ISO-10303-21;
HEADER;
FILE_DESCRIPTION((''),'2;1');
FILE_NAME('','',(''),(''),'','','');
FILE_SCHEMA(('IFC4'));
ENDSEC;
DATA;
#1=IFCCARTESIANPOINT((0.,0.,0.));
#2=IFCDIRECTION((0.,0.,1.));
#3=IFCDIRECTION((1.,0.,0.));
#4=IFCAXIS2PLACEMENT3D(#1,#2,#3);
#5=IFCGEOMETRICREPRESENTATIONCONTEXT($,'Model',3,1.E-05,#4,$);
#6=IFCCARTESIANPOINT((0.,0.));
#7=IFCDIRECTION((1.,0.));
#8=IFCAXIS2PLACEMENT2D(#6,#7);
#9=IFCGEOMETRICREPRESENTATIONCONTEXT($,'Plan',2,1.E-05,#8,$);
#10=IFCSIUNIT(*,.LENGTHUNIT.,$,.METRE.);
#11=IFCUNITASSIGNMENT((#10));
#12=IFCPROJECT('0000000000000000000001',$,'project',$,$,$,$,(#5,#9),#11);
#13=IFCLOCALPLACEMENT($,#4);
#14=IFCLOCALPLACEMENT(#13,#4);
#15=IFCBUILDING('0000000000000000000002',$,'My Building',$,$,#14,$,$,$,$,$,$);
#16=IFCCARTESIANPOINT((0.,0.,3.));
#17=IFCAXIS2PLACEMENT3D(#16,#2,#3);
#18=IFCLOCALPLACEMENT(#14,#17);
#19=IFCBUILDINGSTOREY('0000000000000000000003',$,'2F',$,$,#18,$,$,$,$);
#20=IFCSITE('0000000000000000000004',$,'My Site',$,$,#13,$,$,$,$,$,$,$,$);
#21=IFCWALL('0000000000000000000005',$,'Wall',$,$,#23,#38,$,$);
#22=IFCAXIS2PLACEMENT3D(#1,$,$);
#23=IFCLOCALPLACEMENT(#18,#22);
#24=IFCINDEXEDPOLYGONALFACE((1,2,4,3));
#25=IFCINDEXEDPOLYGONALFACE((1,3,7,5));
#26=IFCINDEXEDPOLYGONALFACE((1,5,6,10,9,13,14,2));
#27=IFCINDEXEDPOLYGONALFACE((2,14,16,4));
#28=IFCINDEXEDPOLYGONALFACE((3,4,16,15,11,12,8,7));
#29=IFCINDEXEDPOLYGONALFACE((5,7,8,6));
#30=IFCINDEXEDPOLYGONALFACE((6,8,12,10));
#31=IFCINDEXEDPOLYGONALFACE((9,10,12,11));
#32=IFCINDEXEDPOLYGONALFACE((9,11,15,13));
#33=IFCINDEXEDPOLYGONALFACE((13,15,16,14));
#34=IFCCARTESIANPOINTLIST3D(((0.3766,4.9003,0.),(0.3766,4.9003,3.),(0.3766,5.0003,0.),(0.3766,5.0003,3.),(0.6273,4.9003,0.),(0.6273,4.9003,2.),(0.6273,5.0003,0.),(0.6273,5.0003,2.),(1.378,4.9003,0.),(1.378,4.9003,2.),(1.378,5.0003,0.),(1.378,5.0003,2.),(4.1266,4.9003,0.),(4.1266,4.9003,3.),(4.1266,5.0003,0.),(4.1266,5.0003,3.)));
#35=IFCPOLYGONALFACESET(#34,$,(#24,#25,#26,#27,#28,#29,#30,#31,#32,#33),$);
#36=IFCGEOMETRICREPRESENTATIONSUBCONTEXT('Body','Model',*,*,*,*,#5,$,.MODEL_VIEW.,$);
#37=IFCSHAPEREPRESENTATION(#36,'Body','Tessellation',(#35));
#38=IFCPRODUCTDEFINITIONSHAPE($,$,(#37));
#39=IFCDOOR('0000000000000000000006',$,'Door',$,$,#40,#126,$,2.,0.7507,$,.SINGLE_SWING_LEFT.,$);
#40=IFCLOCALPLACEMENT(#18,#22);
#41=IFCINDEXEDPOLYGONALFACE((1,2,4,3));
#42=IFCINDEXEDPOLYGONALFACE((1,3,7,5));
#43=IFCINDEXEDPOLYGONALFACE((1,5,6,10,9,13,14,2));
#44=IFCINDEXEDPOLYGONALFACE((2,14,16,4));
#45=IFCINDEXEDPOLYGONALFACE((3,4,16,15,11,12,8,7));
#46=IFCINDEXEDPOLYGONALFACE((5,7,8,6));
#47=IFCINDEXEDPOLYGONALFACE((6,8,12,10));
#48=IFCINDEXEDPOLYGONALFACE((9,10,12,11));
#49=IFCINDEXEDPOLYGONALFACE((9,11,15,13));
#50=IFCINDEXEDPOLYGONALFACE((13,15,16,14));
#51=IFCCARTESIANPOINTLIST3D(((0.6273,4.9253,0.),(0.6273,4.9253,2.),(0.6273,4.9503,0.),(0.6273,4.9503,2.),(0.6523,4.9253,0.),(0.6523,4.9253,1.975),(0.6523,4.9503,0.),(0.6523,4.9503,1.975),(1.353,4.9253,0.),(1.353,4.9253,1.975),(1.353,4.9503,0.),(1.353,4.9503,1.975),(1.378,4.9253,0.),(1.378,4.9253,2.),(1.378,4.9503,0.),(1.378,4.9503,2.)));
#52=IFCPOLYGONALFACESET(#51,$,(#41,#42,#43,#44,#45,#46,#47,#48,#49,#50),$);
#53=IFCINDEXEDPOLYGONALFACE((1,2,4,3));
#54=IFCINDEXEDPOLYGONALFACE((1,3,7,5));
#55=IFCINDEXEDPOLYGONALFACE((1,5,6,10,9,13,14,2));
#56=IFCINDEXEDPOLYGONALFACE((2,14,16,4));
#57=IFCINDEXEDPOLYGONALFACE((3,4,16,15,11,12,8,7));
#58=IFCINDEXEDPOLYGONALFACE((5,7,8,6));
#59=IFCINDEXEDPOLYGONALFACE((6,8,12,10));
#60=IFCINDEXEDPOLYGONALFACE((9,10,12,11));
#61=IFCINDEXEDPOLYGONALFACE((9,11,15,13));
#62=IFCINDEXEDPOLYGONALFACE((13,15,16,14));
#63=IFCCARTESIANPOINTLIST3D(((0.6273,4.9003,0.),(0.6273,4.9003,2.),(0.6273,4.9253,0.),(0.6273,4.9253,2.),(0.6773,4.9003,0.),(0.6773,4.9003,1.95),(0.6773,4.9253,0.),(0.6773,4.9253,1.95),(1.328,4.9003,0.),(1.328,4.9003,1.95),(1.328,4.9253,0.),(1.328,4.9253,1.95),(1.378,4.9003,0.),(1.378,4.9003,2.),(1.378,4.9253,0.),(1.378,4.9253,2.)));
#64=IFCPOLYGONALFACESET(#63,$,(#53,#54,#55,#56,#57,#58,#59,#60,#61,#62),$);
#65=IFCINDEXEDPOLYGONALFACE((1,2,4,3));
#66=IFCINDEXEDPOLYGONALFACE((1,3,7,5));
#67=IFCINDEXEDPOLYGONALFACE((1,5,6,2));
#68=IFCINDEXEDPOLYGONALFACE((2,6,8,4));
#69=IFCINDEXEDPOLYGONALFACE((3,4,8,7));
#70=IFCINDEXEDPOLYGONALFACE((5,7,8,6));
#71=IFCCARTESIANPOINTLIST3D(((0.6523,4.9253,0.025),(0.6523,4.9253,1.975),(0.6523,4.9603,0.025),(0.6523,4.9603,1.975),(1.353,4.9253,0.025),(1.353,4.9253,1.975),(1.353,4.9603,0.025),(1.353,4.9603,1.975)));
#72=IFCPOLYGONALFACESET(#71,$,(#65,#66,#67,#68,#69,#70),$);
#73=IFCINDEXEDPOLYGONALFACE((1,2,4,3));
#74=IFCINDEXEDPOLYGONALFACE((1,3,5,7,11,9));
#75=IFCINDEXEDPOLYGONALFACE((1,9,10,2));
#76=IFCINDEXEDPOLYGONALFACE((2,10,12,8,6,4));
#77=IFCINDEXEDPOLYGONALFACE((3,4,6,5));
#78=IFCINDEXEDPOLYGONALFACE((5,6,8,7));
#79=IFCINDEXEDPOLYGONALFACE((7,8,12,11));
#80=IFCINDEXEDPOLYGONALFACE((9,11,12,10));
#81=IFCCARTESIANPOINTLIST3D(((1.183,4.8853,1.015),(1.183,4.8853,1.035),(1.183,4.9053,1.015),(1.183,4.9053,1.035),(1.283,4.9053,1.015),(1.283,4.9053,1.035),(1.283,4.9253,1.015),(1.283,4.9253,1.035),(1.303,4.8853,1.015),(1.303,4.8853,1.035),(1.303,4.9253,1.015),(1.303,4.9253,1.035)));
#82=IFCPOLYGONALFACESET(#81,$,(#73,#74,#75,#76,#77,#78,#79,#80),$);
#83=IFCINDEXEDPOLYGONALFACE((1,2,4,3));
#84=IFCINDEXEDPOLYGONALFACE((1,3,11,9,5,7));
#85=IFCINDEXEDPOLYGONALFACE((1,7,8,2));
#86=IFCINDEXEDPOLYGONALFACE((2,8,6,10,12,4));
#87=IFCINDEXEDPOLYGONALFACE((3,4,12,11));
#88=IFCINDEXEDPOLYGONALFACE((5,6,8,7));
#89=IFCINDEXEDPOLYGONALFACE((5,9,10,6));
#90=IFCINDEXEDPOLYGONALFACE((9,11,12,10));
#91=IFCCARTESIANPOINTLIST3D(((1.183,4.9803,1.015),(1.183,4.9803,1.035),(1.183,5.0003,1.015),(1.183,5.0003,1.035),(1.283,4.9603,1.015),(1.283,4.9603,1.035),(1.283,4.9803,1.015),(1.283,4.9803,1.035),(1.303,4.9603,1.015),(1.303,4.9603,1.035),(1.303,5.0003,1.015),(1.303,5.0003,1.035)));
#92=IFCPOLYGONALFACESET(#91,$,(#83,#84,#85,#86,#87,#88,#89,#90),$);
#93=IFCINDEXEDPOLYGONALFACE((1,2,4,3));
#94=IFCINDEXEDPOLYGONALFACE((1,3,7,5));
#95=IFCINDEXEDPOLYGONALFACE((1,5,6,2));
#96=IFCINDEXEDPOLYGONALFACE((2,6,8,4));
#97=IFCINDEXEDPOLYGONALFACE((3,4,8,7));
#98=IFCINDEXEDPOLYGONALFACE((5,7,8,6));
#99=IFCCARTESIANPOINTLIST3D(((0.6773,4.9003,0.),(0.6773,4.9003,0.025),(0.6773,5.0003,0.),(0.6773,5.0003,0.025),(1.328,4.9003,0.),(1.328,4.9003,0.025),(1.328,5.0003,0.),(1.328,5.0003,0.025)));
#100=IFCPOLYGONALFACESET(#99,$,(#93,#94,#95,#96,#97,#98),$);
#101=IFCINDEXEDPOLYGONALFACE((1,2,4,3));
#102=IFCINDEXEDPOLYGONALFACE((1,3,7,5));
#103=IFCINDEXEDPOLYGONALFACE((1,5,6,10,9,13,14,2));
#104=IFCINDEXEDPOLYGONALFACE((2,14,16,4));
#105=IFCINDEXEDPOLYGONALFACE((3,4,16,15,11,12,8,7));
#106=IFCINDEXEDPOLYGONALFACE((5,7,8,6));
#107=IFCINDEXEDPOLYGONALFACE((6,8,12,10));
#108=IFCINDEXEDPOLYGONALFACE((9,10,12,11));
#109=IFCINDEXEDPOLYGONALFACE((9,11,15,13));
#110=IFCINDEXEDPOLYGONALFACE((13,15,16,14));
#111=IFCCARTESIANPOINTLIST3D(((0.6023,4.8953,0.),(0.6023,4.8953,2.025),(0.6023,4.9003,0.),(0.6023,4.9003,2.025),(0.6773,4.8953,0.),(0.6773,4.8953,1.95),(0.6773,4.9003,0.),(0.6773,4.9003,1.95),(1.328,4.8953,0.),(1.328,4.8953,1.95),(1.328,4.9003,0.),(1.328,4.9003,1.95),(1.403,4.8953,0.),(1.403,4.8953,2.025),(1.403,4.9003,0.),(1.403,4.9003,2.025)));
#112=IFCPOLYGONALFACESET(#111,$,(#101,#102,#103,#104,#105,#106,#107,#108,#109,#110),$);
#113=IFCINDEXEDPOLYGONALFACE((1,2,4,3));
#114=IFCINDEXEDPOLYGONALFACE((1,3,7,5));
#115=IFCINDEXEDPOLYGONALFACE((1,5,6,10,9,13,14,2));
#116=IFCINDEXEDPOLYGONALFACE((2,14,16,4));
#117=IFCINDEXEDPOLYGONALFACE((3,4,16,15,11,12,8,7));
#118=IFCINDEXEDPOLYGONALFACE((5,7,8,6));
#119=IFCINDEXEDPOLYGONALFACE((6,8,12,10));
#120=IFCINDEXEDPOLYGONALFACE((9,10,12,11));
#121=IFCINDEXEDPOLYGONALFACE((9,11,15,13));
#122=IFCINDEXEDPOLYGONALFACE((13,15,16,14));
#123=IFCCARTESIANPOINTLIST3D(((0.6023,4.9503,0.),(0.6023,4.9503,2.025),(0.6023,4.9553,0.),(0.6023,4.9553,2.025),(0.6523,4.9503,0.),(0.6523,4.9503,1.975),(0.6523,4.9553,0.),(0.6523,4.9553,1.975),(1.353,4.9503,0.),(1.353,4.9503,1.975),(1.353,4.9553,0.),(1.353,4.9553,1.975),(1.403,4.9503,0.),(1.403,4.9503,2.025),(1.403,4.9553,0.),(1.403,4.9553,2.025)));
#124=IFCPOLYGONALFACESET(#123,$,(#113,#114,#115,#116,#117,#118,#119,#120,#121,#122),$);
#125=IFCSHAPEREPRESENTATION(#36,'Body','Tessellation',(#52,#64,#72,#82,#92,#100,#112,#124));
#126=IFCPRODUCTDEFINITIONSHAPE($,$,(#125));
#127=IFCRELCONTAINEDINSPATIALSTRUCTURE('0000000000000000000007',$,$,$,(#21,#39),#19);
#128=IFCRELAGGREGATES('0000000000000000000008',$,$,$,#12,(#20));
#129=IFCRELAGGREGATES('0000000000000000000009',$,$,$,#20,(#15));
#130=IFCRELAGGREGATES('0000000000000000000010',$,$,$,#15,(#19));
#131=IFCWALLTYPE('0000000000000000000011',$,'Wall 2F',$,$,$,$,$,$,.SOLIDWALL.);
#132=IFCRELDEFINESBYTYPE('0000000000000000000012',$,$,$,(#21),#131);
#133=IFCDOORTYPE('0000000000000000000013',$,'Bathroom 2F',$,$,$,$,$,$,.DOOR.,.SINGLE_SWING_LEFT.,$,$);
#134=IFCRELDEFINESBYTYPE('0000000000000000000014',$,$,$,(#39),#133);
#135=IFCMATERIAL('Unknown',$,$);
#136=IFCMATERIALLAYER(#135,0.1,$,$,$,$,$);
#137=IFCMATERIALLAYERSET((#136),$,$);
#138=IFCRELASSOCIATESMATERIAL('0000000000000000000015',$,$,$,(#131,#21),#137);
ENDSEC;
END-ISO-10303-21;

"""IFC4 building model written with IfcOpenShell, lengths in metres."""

from ifc_helpers import new_model, entity, si_unit, frame, origin_with_axes, origin_2d_with_axis, place, context, subcontext, project, spatial, line, indexed_curve, outline, extrude, shape, source, transform, mapped, material, layer, layer_set, layer_usage, type_object, type_shapes, element, fill, save


model = new_model("IFC4")

# Units and contexts
model_context = context("Model", 3, precision=1e-05, world=origin_with_axes())
plan_context = context("Plan", 2, precision=1e-05, world=origin_2d_with_axis())
body_context_1 = subcontext(model_context, "Body", "Model", "MODEL_VIEW")
body_context_2 = subcontext(plan_context, "Body", "Plan", "PLAN_VIEW")
ifc_project = project(units=[si_unit("LENGTHUNIT", "METRE")], contexts=[model_context, plan_context])

# Site, building, storey
site_placement = place(None, origin_with_axes())
site = spatial("IfcSite", under=ifc_project, at=site_placement, Name="My Site")
building_placement = place(site_placement, origin_with_axes())
building = spatial("IfcBuilding", under=site, at=building_placement, Name="My Building")
storey_placement = place(building_placement, frame((0.0, 0.0, 3.0), z_axis=(0.0, 0.0, 1.0), x_axis=(1.0, 0.0, 0.0)))
storey = spatial("IfcBuildingStorey", under=building, at=storey_placement, Name="2F")

# Shared definitions
ifc_material = material(Name="Unknown")
ifc_layer_1 = layer(ifc_material, 0.1)
ifc_layer_set_1 = layer_set([ifc_layer_1])
wall_type_1 = type_object("IfcWallType", Name="Wall 2F", PredefinedType="SOLIDWALL", material=ifc_layer_set_1)

# Wall, opening, door
ifc_layer_usage_1 = layer_usage(ifc_layer_set_1, "AXIS2", "POSITIVE", 0.0)
wall_1_placement = place(storey_placement, frame((4.2266, 5.0003, 0.0), z_axis=(0.0, 0.0, 1.0), x_axis=(-1.0, 0.0, 0.0)))
wall_1 = element("IfcWall", 1, at=wall_1_placement, inside=storey, type_object=wall_type_1, material=ifc_layer_usage_1, Name="Wall", context=body_context_1, shape_type="SweptSolid", body=[
    extrude(outline(indexed_curve([(0.1, 0.0), (0.1, 0.1), (3.85, 0.1), (3.85, 0.0)], segments=[line(1, 2, 3, 4, 1)])), origin_with_axes(), (0.0, 0.0, 1.0), 3.0),
])
shared_shape_1 = source(origin_with_axes(), body_context_1, "Body", "SweptSolid", [
    extrude(outline(indexed_curve([(0.0, 0.0), (0.7507, 0.0), (0.7507, 2.0), (0.0, 2.0)], segments=[line(1, 2, 3, 4, 1)])), frame((0.0, -0.6, 0.0), z_axis=(0.0, -1.0, 0.0), x_axis=(1.0, 0.0, 0.0)), (0.0, 0.0, -1.0), 1.2),
])
opening_1_placement = place(wall_1_placement, frame((3.5993, 0.1, 0.0), z_axis=(0.0, 0.0, 1.0), x_axis=(-1.0, 0.000001, 0.0)))
opening_1 = element("IfcOpeningElement", 2, at=opening_1_placement, cuts=wall_1, PredefinedType="OPENING", context=body_context_1, shape_type="MappedRepresentation", body=[
    mapped(shared_shape_1, transform((0.0, 0.0, 0.0), x_axis=(1.0, 0.0, 0.0), y_axis=(0.0, 1.0, 0.0), z_axis=(0.0, 0.0, 1.0), scale=1.0)),
])
door_type_1 = type_object("IfcDoorType", Name="Bathroom 2F", OperationType="SINGLE_SWING_LEFT", PredefinedType="DOOR")
shared_shape_2 = source(origin_with_axes(), body_context_1, "Body", "SweptSolid", [
    extrude(outline(indexed_curve([(0.0, 0.0), (0.0, 2.0), (0.7507, 2.0), (0.7507, 0.0), (0.7257, 0.0), (0.7257, 1.975), (0.025, 1.975), (0.025, 0.0)], segments=[line(1, 2, 3, 4, 5, 6, 7, 8, 1)])), frame((0.0, 0.025, 0.0), z_axis=(0.0, -1.0, 0.0), x_axis=(1.0, 0.0, 0.0)), (0.0, 0.0, -1.0), 0.025),
    extrude(outline(indexed_curve([(0.0, 0.0), (0.0, 2.0), (0.7507, 2.0), (0.7507, 0.0), (0.7007, 0.0), (0.7007, 1.95), (0.05, 1.95), (0.05, 0.0)], segments=[line(1, 2, 3, 4, 5, 6, 7, 8, 1)])), frame((0.0, 0.0, 0.0), z_axis=(0.0, -1.0, 0.0), x_axis=(1.0, 0.0, 0.0)), (0.0, 0.0, -1.0), 0.025),
    extrude(outline(indexed_curve([(0.0, 0.0), (0.7007, 0.0), (0.7007, 0.035), (0.0, 0.035)], segments=[line(1, 2, 3, 4, 1)])), frame((0.025, 0.025, 0.025), z_axis=(0.0, 0.0, 1.0), x_axis=(1.0, 0.0, 0.0)), (0.0, 0.0, 1.0), 1.95),
    extrude(outline(indexed_curve([(0.0, 0.0), (0.0, -0.04), (-0.12, -0.04), (-0.12, -0.02), (-0.02, -0.02), (-0.02, 0.0)], segments=[line(1, 2, 3, 4, 5, 6, 1)])), frame((0.6757, 0.025, 1.015), z_axis=(0.0, 0.0, 1.0), x_axis=(1.0, 0.0, 0.0)), (0.0, 0.0, 1.0), 0.02),
    extrude(outline(indexed_curve([(0.0, 0.0), (0.0, 0.04), (-0.12, 0.04), (-0.12, 0.02), (-0.02, 0.02), (-0.02, 0.0)], segments=[line(1, 2, 3, 4, 5, 6, 1)])), frame((0.6757, 0.06, 1.015), z_axis=(0.0, 0.0, 1.0), x_axis=(1.0, 0.0, 0.0)), (0.0, 0.0, 1.0), 0.02),
    extrude(outline(indexed_curve([(0.0, 0.0), (0.6507, 0.0), (0.6507, 0.1), (0.0, 0.1)], segments=[line(1, 2, 3, 4, 1)])), frame((0.05, 0.0, 0.0), z_axis=(0.0, 0.0, 1.0), x_axis=(1.0, 0.0, 0.0)), (0.0, 0.0, 1.0), 0.025),
    extrude(outline(indexed_curve([(0.0, 0.0), (0.0, 2.025), (0.8007, 2.025), (0.8007, 0.0), (0.7257, 0.0), (0.7257, 1.95), (0.075, 1.95), (0.075, 0.0)], segments=[line(1, 2, 3, 4, 5, 6, 7, 8, 1)])), frame((-0.025, -0.005, 0.0), z_axis=(0.0, -1.0, 0.0), x_axis=(1.0, 0.0, 0.0)), (0.0, 0.0, -1.0), 0.005),
    extrude(outline(indexed_curve([(0.0, 0.0), (0.0, 2.025), (0.8007, 2.025), (0.8007, 0.0), (0.7507, 0.0), (0.7507, 1.975), (0.05, 1.975), (0.05, 0.0)], segments=[line(1, 2, 3, 4, 5, 6, 7, 8, 1)])), frame((-0.025, 0.05, 0.0), z_axis=(0.0, -1.0, 0.0), x_axis=(1.0, 0.0, 0.0)), (0.0, 0.0, -1.0), 0.005),
])
shared_shape_3 = source(origin_with_axes(), body_context_2, "Body", "Curve2D", [
    entity("IfcIndexedPolyCurve", entity("IfcCartesianPointList2D", [[0.0, 0.0], [0.0, 0.05], [0.025, 0.05], [0.025, 0.025], [0.05, 0.025], [0.05, 0.0]]), [entity("IfcLineIndex", [1, 2, 3, 4, 5, 6, 1])]),
    entity("IfcIndexedPolyCurve", entity("IfcCartesianPointList2D", [[0.7507, 0.0], [0.7507, 0.05], [0.7257, 0.05], [0.7257, 0.025], [0.7007, 0.025], [0.7007, 0.0]]), [entity("IfcLineIndex", [1, 2, 3, 4, 5, 6, 1])]),
    entity("IfcTrimmedCurve", entity("IfcEllipse", entity("IfcAxis2Placement2D", entity("IfcCartesianPoint", [0.06, 0.05]), entity("IfcDirection", [1.0, 0.0])), 0.6657, 0.7007), [entity("IfcCartesianPoint", [0.7257, 0.05])], [entity("IfcCartesianPoint", [0.06, 0.7507])], True, "CARTESIAN"),
    entity("IfcIndexedPolyCurve", entity("IfcCartesianPointList2D", [[0.025, 0.05], [0.06, 0.05], [0.06, 0.7507], [0.025, 0.7507]]), [entity("IfcLineIndex", [1, 2, 3, 4, 1])]),
])
type_shapes(door_type_1, [shared_shape_2, shared_shape_3])
door_1_placement = place(opening_1_placement, frame((0.0, 0.0, 0.0), z_axis=(0.0, 0.0, 1.0), x_axis=(1.0, 0.0, 0.0)))
door_1 = element("IfcDoor", 3, at=door_1_placement, inside=storey, type_object=door_type_1, Name="Door", OperationType="SINGLE_SWING_LEFT", OverallHeight=2.0, OverallWidth=0.7507, shapes=[
    shape(body_context_1, "Body", "MappedRepresentation", [mapped(shared_shape_2, transform((0.0, 0.0, 0.0), x_axis=(1.0, 0.0, 0.0), y_axis=(0.0, 1.0, 0.0), z_axis=(0.0, 0.0, 1.0), scale=1.0))]),
    shape(body_context_2, "Body", "MappedRepresentation", [mapped(shared_shape_3, transform((0.0, 0.0, 0.0), x_axis=(1.0, 0.0, 0.0), y_axis=(0.0, 1.0, 0.0), z_axis=(0.0, 0.0, 1.0), scale=1.0))]),
])
fill(opening_1, door_1)

save(model, "model.ifc")
